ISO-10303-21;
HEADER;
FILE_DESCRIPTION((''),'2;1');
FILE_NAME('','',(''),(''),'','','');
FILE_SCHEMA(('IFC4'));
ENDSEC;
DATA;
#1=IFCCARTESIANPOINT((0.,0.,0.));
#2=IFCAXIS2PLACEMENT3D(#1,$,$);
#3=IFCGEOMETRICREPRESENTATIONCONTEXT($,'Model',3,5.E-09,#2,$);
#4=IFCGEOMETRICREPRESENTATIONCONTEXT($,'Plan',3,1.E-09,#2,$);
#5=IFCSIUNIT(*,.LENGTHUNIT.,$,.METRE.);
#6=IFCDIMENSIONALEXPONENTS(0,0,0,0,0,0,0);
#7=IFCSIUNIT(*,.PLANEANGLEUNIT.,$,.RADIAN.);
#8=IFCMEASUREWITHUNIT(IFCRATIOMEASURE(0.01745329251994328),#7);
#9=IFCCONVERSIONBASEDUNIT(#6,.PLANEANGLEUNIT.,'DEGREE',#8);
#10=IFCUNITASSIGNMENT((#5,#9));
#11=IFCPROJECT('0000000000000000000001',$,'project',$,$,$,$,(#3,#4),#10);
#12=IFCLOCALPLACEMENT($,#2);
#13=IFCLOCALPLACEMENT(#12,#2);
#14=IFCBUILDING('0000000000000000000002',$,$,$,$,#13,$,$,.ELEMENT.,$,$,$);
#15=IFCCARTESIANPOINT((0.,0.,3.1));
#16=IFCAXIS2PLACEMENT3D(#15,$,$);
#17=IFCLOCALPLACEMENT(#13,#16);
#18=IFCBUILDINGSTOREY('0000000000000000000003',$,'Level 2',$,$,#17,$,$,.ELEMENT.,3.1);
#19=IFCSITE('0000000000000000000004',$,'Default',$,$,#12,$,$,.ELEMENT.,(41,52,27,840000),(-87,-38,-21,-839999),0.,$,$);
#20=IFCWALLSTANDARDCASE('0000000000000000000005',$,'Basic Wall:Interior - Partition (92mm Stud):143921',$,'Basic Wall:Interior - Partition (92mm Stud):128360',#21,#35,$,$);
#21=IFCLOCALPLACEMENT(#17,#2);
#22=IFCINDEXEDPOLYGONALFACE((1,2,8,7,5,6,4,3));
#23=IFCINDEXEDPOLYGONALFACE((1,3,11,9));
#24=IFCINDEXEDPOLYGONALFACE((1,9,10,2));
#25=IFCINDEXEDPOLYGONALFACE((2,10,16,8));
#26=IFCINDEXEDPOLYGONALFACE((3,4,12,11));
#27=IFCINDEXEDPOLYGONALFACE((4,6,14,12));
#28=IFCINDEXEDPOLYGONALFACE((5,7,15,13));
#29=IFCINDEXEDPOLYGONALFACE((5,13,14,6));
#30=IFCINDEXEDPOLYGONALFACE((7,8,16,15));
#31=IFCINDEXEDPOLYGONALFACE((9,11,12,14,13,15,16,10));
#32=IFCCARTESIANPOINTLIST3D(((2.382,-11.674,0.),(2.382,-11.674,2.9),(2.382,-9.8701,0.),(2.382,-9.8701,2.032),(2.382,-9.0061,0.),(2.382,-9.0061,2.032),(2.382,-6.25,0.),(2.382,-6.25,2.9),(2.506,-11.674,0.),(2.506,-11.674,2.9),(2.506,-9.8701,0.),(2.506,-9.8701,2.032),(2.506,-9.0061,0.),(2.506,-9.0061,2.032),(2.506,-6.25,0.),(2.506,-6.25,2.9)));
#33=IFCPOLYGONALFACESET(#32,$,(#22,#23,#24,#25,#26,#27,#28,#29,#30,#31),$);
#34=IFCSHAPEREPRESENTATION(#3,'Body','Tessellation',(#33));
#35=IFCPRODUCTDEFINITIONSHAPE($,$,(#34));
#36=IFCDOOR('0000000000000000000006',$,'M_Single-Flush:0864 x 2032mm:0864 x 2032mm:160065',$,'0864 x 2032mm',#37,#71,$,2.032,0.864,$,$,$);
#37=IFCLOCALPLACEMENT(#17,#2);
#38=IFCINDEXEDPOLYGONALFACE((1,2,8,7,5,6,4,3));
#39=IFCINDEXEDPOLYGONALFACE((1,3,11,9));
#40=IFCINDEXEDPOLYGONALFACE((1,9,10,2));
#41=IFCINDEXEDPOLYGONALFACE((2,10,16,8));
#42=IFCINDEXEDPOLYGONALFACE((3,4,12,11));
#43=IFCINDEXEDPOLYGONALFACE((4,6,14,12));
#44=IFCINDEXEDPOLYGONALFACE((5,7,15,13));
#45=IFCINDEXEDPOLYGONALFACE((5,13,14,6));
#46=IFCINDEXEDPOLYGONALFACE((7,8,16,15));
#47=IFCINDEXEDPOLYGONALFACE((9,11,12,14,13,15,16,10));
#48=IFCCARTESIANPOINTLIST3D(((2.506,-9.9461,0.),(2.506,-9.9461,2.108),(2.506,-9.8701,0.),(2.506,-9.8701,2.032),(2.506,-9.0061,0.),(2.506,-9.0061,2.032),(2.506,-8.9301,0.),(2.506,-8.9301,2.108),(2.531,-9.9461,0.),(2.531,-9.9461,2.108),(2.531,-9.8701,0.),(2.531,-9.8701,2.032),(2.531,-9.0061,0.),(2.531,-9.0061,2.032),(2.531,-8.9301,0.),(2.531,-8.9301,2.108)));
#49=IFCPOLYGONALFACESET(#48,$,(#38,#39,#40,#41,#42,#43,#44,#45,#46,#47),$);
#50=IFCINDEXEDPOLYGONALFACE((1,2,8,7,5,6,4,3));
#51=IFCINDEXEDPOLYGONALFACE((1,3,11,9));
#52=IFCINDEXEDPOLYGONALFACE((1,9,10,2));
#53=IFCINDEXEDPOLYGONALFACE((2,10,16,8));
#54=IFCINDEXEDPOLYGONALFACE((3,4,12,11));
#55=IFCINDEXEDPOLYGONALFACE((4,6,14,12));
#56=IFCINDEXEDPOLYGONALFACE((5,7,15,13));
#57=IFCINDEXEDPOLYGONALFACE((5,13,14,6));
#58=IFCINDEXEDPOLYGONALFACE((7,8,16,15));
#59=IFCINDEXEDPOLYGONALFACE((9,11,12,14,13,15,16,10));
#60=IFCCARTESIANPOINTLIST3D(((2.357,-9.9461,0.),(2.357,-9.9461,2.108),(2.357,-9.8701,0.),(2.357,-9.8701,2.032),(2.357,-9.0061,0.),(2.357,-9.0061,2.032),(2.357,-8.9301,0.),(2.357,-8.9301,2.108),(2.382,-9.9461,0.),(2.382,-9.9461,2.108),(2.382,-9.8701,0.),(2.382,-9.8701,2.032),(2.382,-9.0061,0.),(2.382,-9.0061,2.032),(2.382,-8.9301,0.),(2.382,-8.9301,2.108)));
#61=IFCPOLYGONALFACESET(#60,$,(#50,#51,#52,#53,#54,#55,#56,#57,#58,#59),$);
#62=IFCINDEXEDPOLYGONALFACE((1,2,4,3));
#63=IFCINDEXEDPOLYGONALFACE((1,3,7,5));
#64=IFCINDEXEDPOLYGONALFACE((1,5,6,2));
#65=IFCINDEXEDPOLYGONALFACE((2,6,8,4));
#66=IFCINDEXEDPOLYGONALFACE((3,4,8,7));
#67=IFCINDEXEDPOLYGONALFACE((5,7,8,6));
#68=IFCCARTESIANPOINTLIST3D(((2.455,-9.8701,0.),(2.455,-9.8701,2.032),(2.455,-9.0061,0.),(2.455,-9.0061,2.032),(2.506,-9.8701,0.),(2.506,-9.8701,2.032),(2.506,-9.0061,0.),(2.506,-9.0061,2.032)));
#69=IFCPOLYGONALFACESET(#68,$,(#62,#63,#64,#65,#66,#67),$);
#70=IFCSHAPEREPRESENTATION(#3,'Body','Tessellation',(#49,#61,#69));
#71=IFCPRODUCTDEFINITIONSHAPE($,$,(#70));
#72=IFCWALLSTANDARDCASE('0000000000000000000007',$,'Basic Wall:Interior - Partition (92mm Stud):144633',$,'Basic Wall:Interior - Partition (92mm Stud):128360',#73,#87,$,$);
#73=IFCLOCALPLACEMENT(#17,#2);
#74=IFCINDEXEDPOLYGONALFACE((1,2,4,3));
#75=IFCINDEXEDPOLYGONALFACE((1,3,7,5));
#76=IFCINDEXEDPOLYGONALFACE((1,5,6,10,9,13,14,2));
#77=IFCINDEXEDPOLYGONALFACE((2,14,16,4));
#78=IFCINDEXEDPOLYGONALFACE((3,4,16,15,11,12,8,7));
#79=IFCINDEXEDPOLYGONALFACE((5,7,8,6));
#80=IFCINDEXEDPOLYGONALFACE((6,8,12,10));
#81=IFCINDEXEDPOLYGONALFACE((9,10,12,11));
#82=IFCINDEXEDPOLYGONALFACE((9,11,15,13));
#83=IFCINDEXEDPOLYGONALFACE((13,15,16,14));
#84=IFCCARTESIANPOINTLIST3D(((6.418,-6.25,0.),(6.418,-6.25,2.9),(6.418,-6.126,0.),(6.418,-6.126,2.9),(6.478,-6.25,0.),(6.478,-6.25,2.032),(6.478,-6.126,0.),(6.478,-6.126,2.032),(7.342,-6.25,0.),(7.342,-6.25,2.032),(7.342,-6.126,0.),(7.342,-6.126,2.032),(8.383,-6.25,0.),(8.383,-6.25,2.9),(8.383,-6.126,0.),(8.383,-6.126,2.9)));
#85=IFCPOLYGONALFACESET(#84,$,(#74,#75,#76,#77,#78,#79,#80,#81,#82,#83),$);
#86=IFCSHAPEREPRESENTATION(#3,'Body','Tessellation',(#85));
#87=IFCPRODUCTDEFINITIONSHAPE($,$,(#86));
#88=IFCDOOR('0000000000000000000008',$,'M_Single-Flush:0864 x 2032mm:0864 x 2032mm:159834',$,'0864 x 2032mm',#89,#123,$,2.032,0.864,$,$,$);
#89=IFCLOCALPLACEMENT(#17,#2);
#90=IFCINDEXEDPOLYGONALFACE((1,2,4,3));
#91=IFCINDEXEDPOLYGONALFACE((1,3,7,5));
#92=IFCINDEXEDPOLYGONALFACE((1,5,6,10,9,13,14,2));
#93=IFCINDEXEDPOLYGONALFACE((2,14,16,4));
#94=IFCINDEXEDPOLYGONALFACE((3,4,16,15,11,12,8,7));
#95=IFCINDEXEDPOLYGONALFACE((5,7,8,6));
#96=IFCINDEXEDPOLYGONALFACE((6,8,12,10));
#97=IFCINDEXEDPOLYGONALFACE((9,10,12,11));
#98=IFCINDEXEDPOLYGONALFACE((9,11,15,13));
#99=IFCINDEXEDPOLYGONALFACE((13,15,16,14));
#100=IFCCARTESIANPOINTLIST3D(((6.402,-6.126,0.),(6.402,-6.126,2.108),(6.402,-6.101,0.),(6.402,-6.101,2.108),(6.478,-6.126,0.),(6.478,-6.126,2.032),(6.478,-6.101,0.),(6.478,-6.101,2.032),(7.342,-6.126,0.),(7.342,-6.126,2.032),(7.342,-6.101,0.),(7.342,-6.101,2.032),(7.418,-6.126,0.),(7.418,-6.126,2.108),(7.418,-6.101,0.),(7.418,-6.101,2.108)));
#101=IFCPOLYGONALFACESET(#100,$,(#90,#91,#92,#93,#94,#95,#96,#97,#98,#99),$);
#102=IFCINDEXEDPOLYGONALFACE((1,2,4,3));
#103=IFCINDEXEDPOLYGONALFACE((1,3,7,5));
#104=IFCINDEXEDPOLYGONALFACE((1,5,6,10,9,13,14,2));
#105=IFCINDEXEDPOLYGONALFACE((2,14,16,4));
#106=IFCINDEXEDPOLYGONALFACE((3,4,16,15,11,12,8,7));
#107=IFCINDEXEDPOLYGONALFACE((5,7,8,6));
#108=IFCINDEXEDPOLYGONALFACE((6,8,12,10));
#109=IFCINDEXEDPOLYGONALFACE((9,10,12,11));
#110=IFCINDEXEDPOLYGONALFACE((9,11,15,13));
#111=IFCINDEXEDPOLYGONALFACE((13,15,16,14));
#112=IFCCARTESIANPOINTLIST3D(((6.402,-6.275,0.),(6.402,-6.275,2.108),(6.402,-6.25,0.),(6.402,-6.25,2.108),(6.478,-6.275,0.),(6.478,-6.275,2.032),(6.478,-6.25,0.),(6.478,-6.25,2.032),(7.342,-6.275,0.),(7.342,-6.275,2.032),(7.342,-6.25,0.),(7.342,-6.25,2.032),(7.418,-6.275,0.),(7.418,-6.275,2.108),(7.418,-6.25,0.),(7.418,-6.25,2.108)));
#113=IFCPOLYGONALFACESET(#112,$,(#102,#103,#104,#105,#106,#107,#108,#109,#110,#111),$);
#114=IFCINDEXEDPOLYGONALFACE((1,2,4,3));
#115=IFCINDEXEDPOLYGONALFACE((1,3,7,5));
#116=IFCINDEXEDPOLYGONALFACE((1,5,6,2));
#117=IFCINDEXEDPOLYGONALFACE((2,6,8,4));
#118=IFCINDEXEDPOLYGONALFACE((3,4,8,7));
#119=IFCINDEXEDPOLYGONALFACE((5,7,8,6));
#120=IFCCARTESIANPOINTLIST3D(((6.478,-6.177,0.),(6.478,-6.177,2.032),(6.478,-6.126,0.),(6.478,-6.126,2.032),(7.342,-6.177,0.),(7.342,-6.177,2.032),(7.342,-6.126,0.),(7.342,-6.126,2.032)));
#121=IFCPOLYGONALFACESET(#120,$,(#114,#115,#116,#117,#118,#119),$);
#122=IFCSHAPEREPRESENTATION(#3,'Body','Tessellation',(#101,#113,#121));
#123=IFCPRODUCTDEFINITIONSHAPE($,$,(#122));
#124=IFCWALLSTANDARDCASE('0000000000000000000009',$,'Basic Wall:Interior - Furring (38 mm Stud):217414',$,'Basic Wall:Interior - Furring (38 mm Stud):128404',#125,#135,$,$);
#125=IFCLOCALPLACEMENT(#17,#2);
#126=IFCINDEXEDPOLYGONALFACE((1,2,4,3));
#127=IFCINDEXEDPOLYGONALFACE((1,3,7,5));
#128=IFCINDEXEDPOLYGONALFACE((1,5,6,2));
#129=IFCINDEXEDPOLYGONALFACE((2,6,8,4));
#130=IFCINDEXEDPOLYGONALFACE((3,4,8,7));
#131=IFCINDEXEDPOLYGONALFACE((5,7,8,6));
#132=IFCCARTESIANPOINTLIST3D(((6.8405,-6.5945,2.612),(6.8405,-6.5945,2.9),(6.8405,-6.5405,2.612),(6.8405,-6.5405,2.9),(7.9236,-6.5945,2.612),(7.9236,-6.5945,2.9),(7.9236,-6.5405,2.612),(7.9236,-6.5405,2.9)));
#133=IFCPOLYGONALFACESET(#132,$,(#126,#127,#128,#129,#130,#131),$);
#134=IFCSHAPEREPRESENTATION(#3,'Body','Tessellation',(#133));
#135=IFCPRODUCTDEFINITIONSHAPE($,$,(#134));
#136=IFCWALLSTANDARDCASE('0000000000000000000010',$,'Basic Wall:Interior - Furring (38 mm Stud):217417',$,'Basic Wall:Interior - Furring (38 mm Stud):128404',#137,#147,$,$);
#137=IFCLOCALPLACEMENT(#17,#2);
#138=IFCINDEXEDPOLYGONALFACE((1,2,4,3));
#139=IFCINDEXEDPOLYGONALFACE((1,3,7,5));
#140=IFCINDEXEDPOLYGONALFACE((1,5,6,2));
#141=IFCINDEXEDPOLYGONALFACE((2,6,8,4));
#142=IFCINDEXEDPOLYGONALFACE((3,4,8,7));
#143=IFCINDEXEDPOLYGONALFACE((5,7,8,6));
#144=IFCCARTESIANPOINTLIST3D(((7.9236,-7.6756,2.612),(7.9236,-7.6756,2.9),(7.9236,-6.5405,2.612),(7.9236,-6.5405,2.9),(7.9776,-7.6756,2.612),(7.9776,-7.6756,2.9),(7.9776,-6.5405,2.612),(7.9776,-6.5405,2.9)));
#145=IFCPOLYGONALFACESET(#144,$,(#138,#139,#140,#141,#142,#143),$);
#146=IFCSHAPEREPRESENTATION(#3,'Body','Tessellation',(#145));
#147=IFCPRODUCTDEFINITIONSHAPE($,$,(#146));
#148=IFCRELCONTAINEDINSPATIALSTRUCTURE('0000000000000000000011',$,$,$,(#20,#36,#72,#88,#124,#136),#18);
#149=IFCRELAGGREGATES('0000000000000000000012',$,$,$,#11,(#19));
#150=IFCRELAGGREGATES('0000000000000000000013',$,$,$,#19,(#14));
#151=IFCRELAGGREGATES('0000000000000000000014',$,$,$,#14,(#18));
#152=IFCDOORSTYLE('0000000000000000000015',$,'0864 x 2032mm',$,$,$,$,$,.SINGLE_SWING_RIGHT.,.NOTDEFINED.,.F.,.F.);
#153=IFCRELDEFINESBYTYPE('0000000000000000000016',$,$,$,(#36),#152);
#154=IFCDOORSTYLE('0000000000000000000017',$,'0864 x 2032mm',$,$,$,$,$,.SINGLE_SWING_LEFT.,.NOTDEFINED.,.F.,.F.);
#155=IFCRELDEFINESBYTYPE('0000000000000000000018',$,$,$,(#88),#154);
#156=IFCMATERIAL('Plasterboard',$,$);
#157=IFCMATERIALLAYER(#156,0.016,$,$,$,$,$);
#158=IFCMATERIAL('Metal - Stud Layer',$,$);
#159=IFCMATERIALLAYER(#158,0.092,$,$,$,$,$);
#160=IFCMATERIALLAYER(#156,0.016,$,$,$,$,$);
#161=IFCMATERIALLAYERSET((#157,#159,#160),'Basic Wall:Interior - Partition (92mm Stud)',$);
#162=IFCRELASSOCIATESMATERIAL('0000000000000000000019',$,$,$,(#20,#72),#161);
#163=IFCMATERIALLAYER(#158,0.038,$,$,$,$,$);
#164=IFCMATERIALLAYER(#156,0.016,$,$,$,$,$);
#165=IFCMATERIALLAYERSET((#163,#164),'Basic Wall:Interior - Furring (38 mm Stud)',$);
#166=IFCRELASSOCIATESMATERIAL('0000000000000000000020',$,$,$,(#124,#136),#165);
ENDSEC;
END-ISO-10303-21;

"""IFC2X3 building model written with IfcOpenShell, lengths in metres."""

from ifc_helpers import new_model, entity, si_unit, converted_unit, frame, frame_2d, origin, origin_2d_with_axis, place, context, project, spatial, polyline, rectangle, outline, extrude, source, transform, mapped, material, layer, layer_set, layer_usage, type_object, type_shapes, element, fill, save


model = new_model("IFC2X3")

# Units and contexts
model_context = context("Model", 3, precision=5e-09, world=origin())
plan_context = context("Plan", 3, precision=1e-09, world=origin())
ifc_project = project(units=[si_unit("LENGTHUNIT", "METRE"), converted_unit("PLANEANGLEUNIT", "DEGREE", entity("IfcRatioMeasure", 0.01745329251994328), si_unit("PLANEANGLEUNIT", "RADIAN"), dimensions=[0, 0, 0, 0, 0, 0, 0])], contexts=[model_context, plan_context])

# Site, building, storey
site_placement = place(None, origin())
site = spatial("IfcSite", under=ifc_project, at=site_placement, Name="Default", CompositionType="ELEMENT", RefLatitude=(41, 52, 27, 840000), RefLongitude=(-87, -38, -21, -839999), RefElevation=0.0)
building_placement = place(site_placement, origin())
building = spatial("IfcBuilding", under=site, at=building_placement, CompositionType="ELEMENT")
storey_placement = place(building_placement, frame((0.0, 0.0, 3.1)))
storey = spatial("IfcBuildingStorey", under=building, at=storey_placement, Name="Level 2", CompositionType="ELEMENT", Elevation=3.1)

# Wall, opening, door
ifc_material_1 = material(Name="Plasterboard")
ifc_layer_1 = layer(ifc_material_1, 0.016)
ifc_material_2 = material(Name="Metal - Stud Layer")
ifc_layer_2 = layer(ifc_material_2, 0.092)
ifc_layer_3 = layer(ifc_material_1, 0.016)
ifc_layer_set_1 = layer_set([ifc_layer_1, ifc_layer_2, ifc_layer_3], Name="Basic Wall:Interior - Partition (92mm Stud)")
ifc_layer_usage_1 = layer_usage(ifc_layer_set_1, "AXIS2", "NEGATIVE", 0.062)
wall_1_placement = place(storey_placement, frame((2.444, -6.25, 0.0), z_axis=(0.0, 0.0, 1.0), x_axis=(0.0, -1.0, 0.0)))
wall_1 = element("IfcWallStandardCase", 1, at=wall_1_placement, inside=storey, material=ifc_layer_usage_1, Name="Basic Wall:Interior - Partition (92mm Stud):143921", ObjectType="Basic Wall:Interior - Partition (92mm Stud):128360", context=model_context, shape_type="SweptSolid", body=[
    extrude(rectangle(XDim=5.424, YDim=0.124, at=frame_2d((2.712, 0.0), x_axis=(-1.0, 0.0))), origin(), (0.0, 0.0, 1.0), 2.9),
])
opening_1_placement = place(wall_1_placement, frame((2.7561, -0.062, 0.0)))
opening_1 = element("IfcOpeningElement", 2, at=opening_1_placement, cuts=wall_1, ObjectType="Opening", context=model_context, shape_type="SweptSolid", body=[
    extrude(rectangle(XDim=0.864, YDim=2.032, at=frame_2d((1.016, 0.432), x_axis=(0.0, 1.0))), frame((0.0, 0.0, 0.0), z_axis=(0.0, 1.0, 0.0), x_axis=(0.0, 0.0, 1.0)), (0.0, 0.0, 1.0), 0.124),
])
door_style_1 = type_object("IfcDoorStyle", Name="0864 x 2032mm", ConstructionType="NOTDEFINED", OperationType="SINGLE_SWING_RIGHT", ParameterTakesPrecedence=False, Sizeable=False)
shared_shape_1 = source(origin(), model_context, "Body", "SweptSolid", [
    extrude(outline(polyline([(-0.508, -1.073), (0.508, -1.073), (0.508, 1.035), (0.432, 1.035), (0.432, -0.997), (-0.432, -0.997), (-0.432, 1.035), (-0.508, 1.035), (-0.508, -1.073)])), frame((0.432, 0.124, 1.035), z_axis=(0.0, 1.0, 0.0), x_axis=(1.0, 0.0, 0.0)), (0.0, 0.0, 1.0), 0.025),
    extrude(outline(polyline([(-1.073, -0.508), (1.035, -0.508), (1.035, -0.432), (-0.997, -0.432), (-0.997, 0.432), (1.035, 0.432), (1.035, 0.508), (-1.073, 0.508), (-1.073, -0.508)])), frame((0.432, -0.025, 1.035), z_axis=(0.0, 1.0, 0.0), x_axis=(0.0, 0.0, -1.0)), (0.0, 0.0, 1.0), 0.025),
    extrude(rectangle(XDim=0.051, YDim=0.864, at=origin_2d_with_axis()), frame((0.432, 0.0985, 0.0), z_axis=(0.0, 0.0, 1.0), x_axis=(0.0, 1.0, 0.0)), (0.0, 0.0, 1.0), 2.032),
])
type_shapes(door_style_1, [shared_shape_1])
door_1_placement = place(opening_1_placement, origin())
door_1 = element("IfcDoor", 3, at=door_1_placement, inside=storey, type_object=door_style_1, Name="M_Single-Flush:0864 x 2032mm:0864 x 2032mm:160065", ObjectType="0864 x 2032mm", OverallHeight=2.032, OverallWidth=0.864, context=model_context, shape_type="MappedRepresentation", body=[
    mapped(shared_shape_1, transform((0.0, 0.0, 0.0), scale=1.0)),
])
fill(opening_1, door_1)

# Wall, opening, door
wall_2_placement = place(storey_placement, frame((6.418, -6.188, 0.0)))
wall_2 = element("IfcWallStandardCase", 4, at=wall_2_placement, inside=storey, material=ifc_layer_usage_1, Name="Basic Wall:Interior - Partition (92mm Stud):144633", ObjectType="Basic Wall:Interior - Partition (92mm Stud):128360", context=model_context, shape_type="SweptSolid", body=[
    extrude(rectangle(XDim=1.965, YDim=0.124, at=frame_2d((0.9825, 0.0), x_axis=(-1.0, 0.0))), origin(), (0.0, 0.0, 1.0), 2.9),
])
opening_2_placement = place(wall_2_placement, frame((0.06, -0.062, 0.0)))
opening_2 = element("IfcOpeningElement", 5, at=opening_2_placement, cuts=wall_2, ObjectType="Opening", context=model_context, shape_type="SweptSolid", body=[
    extrude(rectangle(XDim=0.864, YDim=2.032, at=frame_2d((1.016, 0.432), x_axis=(0.0, -1.0))), frame((0.0, 0.0, 0.0), z_axis=(0.0, 1.0, 0.0), x_axis=(0.0, 0.0, 1.0)), (0.0, 0.0, 1.0), 0.124),
])
door_style_2 = type_object("IfcDoorStyle", Name="0864 x 2032mm", ConstructionType="NOTDEFINED", OperationType="SINGLE_SWING_LEFT", ParameterTakesPrecedence=False, Sizeable=False)
shared_shape_2 = source(origin(), model_context, "Body", "SweptSolid", [
    extrude(outline(polyline([(-0.508, -1.073), (0.508, -1.073), (0.508, 1.035), (0.432, 1.035), (0.432, -0.997), (-0.432, -0.997), (-0.432, 1.035), (-0.508, 1.035), (-0.508, -1.073)])), frame((0.432, 0.149, 1.035), z_axis=(0.0, -1.0, 0.0), x_axis=(-1.0, 0.0, 0.0)), (0.0, 0.0, 1.0), 0.025),
    extrude(outline(polyline([(-1.073, -0.508), (1.035, -0.508), (1.035, -0.432), (-0.997, -0.432), (-0.997, 0.432), (1.035, 0.432), (1.035, 0.508), (-1.073, 0.508), (-1.073, -0.508)])), frame((0.432, 0.0, 1.035), z_axis=(0.0, -1.0, 0.0), x_axis=(0.0, 0.0, -1.0)), (0.0, 0.0, 1.0), 0.025),
    extrude(rectangle(XDim=0.864, YDim=0.051, at=origin_2d_with_axis()), frame((0.432, 0.0985, 0.0)), (0.0, 0.0, 1.0), 2.032),
])
type_shapes(door_style_2, [shared_shape_2])
door_2_placement = place(opening_2_placement, origin())
door_2 = element("IfcDoor", 6, at=door_2_placement, inside=storey, type_object=door_style_2, Name="M_Single-Flush:0864 x 2032mm:0864 x 2032mm:159834", ObjectType="0864 x 2032mm", OverallHeight=2.032, OverallWidth=0.864, context=model_context, shape_type="MappedRepresentation", body=[
    mapped(shared_shape_2, transform((0.0, 0.0, 0.0), scale=1.0)),
])
fill(opening_2, door_2)

# Walls
ifc_layer_4 = layer(ifc_material_2, 0.038)
ifc_layer_5 = layer(ifc_material_1, 0.016)
ifc_layer_set_2 = layer_set([ifc_layer_4, ifc_layer_5], Name="Basic Wall:Interior - Furring (38 mm Stud)")
ifc_layer_usage_2 = layer_usage(ifc_layer_set_2, "AXIS2", "NEGATIVE", 0.027)
wall_3_placement = place(storey_placement, frame((6.8405, -6.5675, 2.612)))
element("IfcWallStandardCase", 7, at=wall_3_placement, inside=storey, material=ifc_layer_usage_2, Name="Basic Wall:Interior - Furring (38 mm Stud):217414", ObjectType="Basic Wall:Interior - Furring (38 mm Stud):128404", context=model_context, shape_type="SweptSolid", body=[
    extrude(rectangle(XDim=1.0831, YDim=0.054, at=frame_2d((0.5416, 0.0), x_axis=(-1.0, 0.0))), origin(), (0.0, 0.0, 1.0), 0.288),
])
wall_4_placement = place(storey_placement, frame((7.9506, -6.5405, 2.612), z_axis=(0.0, 0.0, 1.0), x_axis=(0.0, -1.0, 0.0)))
element("IfcWallStandardCase", 8, at=wall_4_placement, inside=storey, material=ifc_layer_usage_2, Name="Basic Wall:Interior - Furring (38 mm Stud):217417", ObjectType="Basic Wall:Interior - Furring (38 mm Stud):128404", context=model_context, shape_type="SweptSolid", body=[
    extrude(rectangle(XDim=1.1351, YDim=0.054, at=frame_2d((0.5675, 0.0), x_axis=(-1.0, 0.0))), origin(), (0.0, 0.0, 1.0), 0.288),
])

save(model, "model.ifc")
